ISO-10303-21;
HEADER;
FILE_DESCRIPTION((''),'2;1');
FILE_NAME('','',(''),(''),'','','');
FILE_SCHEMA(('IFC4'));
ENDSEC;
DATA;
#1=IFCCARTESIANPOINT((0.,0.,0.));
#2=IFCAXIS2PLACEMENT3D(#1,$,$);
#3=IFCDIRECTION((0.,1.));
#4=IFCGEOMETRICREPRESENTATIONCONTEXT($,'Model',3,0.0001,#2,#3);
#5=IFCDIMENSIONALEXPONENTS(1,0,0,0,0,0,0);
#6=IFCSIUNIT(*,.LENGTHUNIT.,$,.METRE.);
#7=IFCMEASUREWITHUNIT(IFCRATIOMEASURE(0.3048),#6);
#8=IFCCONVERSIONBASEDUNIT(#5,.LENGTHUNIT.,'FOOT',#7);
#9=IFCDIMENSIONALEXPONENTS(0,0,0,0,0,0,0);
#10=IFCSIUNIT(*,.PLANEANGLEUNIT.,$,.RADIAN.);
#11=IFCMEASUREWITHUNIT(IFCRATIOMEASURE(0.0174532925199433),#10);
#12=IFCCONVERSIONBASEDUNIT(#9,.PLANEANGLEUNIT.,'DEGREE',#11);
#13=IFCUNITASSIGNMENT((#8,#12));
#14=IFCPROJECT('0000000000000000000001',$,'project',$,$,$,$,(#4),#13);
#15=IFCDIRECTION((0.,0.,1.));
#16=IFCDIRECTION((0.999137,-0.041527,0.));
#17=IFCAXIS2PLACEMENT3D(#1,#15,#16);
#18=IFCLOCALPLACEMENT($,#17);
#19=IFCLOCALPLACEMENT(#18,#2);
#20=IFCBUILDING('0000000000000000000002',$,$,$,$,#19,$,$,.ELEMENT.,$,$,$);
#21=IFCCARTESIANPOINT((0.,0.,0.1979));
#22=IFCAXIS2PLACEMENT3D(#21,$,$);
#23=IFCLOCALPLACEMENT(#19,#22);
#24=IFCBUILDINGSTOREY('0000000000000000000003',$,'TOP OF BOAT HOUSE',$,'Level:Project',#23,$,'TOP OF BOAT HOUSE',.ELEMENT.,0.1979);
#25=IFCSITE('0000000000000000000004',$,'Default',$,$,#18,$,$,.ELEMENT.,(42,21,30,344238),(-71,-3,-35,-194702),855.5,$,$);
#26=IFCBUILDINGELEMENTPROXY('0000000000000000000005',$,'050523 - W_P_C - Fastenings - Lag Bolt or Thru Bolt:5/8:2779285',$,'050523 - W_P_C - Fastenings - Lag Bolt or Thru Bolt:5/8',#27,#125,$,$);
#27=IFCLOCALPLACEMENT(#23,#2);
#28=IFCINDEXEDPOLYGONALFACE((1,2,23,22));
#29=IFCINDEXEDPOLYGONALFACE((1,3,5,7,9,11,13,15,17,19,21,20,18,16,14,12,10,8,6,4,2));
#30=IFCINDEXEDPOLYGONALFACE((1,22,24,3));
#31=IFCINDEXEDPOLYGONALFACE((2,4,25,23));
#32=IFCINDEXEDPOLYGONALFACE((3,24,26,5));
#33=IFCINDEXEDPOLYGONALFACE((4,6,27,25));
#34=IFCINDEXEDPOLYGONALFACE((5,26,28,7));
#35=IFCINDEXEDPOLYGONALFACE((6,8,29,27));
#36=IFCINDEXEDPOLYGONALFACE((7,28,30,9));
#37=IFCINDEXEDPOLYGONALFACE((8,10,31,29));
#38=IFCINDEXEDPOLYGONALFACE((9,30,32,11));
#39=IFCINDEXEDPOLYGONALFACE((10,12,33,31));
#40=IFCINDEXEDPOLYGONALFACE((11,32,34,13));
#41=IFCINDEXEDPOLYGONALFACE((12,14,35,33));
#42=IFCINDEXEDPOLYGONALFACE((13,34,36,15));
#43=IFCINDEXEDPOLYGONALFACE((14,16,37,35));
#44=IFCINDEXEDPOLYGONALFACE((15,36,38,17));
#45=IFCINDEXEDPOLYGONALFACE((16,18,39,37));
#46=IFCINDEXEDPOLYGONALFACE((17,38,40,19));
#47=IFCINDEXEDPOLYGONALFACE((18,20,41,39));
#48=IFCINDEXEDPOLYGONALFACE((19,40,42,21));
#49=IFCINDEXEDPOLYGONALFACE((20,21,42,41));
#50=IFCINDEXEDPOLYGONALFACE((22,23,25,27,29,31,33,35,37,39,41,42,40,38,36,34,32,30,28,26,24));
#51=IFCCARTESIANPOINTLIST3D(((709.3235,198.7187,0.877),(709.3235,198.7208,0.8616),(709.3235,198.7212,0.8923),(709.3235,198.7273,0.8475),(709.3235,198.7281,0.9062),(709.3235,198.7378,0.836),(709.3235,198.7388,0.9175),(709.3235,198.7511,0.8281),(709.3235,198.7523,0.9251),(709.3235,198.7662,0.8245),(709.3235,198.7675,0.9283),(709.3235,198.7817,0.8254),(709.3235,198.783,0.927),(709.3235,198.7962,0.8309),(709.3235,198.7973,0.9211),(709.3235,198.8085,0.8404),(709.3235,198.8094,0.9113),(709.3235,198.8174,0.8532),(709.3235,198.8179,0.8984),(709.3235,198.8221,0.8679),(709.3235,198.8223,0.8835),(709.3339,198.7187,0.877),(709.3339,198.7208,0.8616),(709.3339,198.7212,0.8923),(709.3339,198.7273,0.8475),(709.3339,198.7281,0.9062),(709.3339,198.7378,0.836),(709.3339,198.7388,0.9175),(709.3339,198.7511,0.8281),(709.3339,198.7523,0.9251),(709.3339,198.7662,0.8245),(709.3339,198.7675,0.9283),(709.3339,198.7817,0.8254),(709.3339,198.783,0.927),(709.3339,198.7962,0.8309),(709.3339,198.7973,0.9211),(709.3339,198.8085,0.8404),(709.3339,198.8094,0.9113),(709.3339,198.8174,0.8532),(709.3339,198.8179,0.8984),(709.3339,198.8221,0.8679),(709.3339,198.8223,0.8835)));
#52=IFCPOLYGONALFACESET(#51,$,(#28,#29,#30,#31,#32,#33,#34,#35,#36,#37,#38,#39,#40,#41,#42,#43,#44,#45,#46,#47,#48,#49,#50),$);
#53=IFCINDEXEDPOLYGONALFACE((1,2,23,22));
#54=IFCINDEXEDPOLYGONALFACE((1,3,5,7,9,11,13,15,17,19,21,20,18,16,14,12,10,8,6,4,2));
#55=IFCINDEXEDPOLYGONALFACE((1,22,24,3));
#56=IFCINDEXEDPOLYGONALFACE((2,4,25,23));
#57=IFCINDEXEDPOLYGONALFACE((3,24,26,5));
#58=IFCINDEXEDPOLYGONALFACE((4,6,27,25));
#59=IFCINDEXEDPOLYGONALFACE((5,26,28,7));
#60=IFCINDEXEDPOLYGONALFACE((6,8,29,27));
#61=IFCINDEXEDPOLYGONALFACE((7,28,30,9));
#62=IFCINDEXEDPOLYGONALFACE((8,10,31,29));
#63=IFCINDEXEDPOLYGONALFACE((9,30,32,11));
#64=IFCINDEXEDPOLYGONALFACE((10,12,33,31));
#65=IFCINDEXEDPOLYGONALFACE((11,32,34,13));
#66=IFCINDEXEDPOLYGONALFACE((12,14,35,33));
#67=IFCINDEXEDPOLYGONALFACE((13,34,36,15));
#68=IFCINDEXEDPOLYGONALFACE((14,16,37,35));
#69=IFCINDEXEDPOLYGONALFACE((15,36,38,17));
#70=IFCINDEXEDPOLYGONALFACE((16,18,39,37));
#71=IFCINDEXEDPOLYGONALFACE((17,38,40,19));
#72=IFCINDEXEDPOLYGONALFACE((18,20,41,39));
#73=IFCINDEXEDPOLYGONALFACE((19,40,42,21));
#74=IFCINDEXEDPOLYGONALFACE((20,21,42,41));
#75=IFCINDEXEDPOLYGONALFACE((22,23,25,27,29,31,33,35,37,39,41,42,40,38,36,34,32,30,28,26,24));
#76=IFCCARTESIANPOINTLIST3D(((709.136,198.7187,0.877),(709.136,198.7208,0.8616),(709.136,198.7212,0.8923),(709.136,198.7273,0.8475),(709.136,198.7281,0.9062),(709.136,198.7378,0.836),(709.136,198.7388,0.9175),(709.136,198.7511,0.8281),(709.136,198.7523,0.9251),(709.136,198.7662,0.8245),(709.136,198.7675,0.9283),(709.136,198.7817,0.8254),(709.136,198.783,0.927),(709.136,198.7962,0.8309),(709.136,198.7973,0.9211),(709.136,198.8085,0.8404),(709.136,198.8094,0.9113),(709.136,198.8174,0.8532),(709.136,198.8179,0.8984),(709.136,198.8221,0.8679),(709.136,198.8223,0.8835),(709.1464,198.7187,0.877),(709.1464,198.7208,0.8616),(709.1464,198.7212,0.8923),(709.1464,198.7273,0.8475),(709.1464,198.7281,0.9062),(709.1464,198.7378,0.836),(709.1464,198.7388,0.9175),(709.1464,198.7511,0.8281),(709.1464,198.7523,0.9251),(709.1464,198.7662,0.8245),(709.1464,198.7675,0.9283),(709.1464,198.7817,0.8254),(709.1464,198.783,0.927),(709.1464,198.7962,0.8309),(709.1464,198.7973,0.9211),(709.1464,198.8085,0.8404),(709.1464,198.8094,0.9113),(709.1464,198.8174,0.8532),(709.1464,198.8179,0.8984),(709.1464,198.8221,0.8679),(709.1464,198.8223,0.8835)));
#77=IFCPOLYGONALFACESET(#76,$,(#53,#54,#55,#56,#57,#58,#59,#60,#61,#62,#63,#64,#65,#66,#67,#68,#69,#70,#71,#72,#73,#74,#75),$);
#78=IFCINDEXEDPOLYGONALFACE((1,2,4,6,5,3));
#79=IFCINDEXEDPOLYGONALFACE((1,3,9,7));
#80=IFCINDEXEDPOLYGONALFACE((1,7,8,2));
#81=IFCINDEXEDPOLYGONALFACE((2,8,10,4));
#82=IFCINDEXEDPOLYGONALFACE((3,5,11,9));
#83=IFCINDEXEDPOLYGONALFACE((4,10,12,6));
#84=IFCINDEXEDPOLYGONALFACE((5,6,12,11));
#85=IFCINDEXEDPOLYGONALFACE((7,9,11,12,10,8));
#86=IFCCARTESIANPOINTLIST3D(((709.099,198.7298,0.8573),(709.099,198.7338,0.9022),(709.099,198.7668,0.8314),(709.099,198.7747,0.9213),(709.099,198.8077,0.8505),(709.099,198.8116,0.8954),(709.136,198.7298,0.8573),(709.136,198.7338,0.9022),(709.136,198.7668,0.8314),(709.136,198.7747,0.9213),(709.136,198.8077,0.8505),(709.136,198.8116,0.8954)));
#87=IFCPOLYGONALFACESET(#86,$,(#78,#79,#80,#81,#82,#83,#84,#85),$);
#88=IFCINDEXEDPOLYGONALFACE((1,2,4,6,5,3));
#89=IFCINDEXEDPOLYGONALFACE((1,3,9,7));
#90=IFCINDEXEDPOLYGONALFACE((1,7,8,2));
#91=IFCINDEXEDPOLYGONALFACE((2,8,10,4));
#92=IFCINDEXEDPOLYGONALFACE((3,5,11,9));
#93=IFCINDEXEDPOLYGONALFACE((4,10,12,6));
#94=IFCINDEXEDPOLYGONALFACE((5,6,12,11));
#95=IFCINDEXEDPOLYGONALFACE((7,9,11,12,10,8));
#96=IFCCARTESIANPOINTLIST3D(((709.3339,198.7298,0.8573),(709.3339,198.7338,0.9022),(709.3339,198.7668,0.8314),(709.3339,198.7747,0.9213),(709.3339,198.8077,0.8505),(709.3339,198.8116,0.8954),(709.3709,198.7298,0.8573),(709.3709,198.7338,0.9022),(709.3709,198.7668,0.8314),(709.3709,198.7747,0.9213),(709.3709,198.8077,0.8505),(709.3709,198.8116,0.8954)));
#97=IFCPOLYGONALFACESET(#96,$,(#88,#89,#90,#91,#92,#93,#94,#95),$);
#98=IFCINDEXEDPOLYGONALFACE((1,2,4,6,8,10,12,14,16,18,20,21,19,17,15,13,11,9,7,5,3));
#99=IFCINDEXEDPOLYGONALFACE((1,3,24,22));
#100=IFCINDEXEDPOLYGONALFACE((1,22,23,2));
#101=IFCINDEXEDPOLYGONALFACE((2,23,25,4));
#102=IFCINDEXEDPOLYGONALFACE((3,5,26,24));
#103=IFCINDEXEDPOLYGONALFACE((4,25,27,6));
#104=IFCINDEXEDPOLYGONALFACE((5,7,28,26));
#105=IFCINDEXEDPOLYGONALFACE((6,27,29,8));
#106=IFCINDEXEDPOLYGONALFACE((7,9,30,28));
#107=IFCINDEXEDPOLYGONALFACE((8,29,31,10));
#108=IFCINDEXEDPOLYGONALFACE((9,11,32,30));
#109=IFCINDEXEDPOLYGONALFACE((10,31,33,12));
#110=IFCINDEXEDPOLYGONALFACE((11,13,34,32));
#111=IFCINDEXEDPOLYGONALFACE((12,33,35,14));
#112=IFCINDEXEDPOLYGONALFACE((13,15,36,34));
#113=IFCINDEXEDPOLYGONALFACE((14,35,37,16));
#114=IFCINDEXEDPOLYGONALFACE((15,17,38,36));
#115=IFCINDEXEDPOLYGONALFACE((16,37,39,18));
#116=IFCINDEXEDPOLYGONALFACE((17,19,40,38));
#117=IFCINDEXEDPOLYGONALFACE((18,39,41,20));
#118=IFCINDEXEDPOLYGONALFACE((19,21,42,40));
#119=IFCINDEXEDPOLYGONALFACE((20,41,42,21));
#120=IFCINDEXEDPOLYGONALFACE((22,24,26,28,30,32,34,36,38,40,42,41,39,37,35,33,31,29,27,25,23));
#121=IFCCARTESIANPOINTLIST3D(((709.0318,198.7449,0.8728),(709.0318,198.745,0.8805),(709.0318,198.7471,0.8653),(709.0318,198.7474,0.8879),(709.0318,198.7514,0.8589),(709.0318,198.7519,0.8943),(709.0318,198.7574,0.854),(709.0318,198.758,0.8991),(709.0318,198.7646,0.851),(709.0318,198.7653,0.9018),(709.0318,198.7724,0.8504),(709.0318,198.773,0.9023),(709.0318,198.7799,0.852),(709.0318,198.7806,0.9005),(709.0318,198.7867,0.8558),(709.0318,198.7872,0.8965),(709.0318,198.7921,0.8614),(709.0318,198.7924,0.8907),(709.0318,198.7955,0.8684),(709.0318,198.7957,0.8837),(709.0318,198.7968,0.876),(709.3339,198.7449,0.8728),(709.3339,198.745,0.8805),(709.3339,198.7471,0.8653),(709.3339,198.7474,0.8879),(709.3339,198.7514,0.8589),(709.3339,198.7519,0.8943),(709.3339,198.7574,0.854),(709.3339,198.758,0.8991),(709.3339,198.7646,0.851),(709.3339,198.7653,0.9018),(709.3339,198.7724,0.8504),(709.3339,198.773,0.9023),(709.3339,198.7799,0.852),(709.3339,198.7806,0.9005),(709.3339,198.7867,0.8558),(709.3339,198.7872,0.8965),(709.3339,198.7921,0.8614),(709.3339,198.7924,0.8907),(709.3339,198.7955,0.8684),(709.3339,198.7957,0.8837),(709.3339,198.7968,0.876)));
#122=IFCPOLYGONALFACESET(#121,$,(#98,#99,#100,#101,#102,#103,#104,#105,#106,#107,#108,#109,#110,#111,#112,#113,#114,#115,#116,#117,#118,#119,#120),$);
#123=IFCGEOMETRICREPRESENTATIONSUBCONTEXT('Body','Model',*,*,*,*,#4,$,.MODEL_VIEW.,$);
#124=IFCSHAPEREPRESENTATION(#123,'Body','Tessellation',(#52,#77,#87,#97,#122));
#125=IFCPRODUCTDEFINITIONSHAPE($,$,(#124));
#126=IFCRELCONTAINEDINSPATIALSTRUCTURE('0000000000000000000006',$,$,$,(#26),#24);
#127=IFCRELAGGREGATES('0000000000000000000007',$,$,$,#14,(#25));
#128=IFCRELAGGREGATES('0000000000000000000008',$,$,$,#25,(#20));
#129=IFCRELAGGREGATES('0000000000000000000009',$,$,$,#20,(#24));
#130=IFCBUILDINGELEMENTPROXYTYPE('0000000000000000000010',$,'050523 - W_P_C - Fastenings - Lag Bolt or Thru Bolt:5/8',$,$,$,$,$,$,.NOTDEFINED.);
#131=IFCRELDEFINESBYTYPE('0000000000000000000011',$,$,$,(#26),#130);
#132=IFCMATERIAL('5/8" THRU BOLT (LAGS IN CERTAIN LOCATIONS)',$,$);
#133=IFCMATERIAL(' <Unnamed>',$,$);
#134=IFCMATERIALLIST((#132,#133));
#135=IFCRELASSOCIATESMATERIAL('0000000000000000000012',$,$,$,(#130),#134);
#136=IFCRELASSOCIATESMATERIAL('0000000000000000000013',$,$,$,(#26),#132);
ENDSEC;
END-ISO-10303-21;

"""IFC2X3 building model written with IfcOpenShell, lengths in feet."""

from ifc_helpers import new_model, entity, si_unit, converted_unit, direction, frame, frame_2d, origin, place, context, subcontext, project, spatial, polyline, circle, outline, extrude, source, transform, mapped, material, material_list, type_object, type_shapes, element, save


model = new_model("IFC2X3")

# Units and contexts
model_context = context("Model", 3, precision=0.0001, world=origin(), true_north=direction((0.0, 1.0)))
body_context = subcontext(model_context, "Body", "Model", "MODEL_VIEW")
ifc_project = project(units=[converted_unit("LENGTHUNIT", "FOOT", entity("IfcRatioMeasure", 0.3048), si_unit("LENGTHUNIT", "METRE"), dimensions=[1, 0, 0, 0, 0, 0, 0]), converted_unit("PLANEANGLEUNIT", "DEGREE", entity("IfcRatioMeasure", 0.0174532925199433), si_unit("PLANEANGLEUNIT", "RADIAN"), dimensions=[0, 0, 0, 0, 0, 0, 0])], contexts=[model_context])

# Site, building, storey
site_placement = place(None, frame((0.0, 0.0, 0.0), z_axis=(0.0, 0.0, 1.0), x_axis=(0.999137, -0.041527, 0.0)))
site = spatial("IfcSite", under=ifc_project, at=site_placement, Name="Default", CompositionType="ELEMENT", RefLatitude=(42, 21, 30, 344238), RefLongitude=(-71, -3, -35, -194702), RefElevation=855.5)
building_placement = place(site_placement, origin())
building = spatial("IfcBuilding", under=site, at=building_placement, CompositionType="ELEMENT")
storey_placement = place(building_placement, frame((0.0, 0.0, 0.1979)))
storey = spatial("IfcBuildingStorey", under=building, at=storey_placement, Name="TOP OF BOAT HOUSE", ObjectType="Level:Project", LongName="TOP OF BOAT HOUSE", CompositionType="ELEMENT", Elevation=0.1979)

# Building element proxy
ifc_material_1 = material(Name="5/8\" THRU BOLT (LAGS IN CERTAIN LOCATIONS)")
ifc_material_2 = material(Name=" <Unnamed>")
ifc_material_list_1 = material_list([ifc_material_1, ifc_material_2])
building_element_proxy_type_1 = type_object("IfcBuildingElementProxyType", Name="050523 - W_P_C - Fastenings - Lag Bolt or Thru Bolt:5/8", PredefinedType="NOTDEFINED", material=ifc_material_list_1)
shared_shape_1 = source(origin(), body_context, "Body", "SweptSolid", [
    extrude(circle(Radius=0.0521, at=frame_2d((0.0, 0.0), x_axis=(1.0, 0.0))), frame((0.0, 0.0, 0.0), z_axis=(0.0, 0.0, 1.0), x_axis=(0.0, -1.0, 0.0)), (0.0, 0.0, 1.0), 0.0104),
    extrude(circle(Radius=0.0521, at=frame_2d((0.0, 0.0), x_axis=(1.0, 0.0))), frame((0.0, 0.0, -0.1875), z_axis=(0.0, 0.0, 1.0), x_axis=(0.0, -1.0, 0.0)), (0.0, 0.0, 1.0), 0.0104),
    extrude(outline(polyline([(-0.0226, -0.0391), (0.0226, -0.0391), (0.0451, 0.0), (0.0226, 0.0391), (-0.0226, 0.0391), (-0.0451, 0.0), (-0.0226, -0.0391)])), frame((0.0, 0.0, -0.2245), z_axis=(0.0, 0.0, 1.0), x_axis=(0.866025, -0.5, 0.0)), (0.0, 0.0, 1.0), 0.037),
    extrude(outline(polyline([(-0.0226, -0.0391), (0.0226, -0.0391), (0.0451, 0.0), (0.0226, 0.0391), (-0.0226, 0.0391), (-0.0451, 0.0), (-0.0226, -0.0391)])), frame((0.0, 0.0, 0.0104), z_axis=(0.0, 0.0, 1.0), x_axis=(0.0, -1.0, 0.0)), (0.0, 0.0, 1.0), 0.037),
    extrude(circle(Radius=0.026, at=frame_2d((0.0, 0.0), x_axis=(1.0, 0.0))), frame((0.0, 0.0, -0.2917), z_axis=(0.0, 0.0, 1.0), x_axis=(0.0, 1.0, 0.0)), (0.0, 0.0, 1.0), 0.3021),
])
type_shapes(building_element_proxy_type_1, [shared_shape_1])
for number, where, z_axis, x_axis, name in (
    (1, (709.3235, 198.7707, 0.8763), (1.0, 0.0, 0.0), (0.0, 0.996195, -0.087156), "050523 - W_P_C - Fastenings - Lag Bolt or Thru Bolt:5/8:2779285"),
):
    element("IfcBuildingElementProxy", number, at=place(storey_placement, frame(where, z_axis=z_axis, x_axis=x_axis)), inside=storey, type_object=building_element_proxy_type_1, material=ifc_material_1, Name=name, ObjectType="050523 - W_P_C - Fastenings - Lag Bolt or Thru Bolt:5/8", context=body_context, shape_type="MappedRepresentation", body=[
        mapped(shared_shape_1, transform((0.0, 0.0, 0.0), scale=1.0)),
    ])

save(model, "model.ifc")
